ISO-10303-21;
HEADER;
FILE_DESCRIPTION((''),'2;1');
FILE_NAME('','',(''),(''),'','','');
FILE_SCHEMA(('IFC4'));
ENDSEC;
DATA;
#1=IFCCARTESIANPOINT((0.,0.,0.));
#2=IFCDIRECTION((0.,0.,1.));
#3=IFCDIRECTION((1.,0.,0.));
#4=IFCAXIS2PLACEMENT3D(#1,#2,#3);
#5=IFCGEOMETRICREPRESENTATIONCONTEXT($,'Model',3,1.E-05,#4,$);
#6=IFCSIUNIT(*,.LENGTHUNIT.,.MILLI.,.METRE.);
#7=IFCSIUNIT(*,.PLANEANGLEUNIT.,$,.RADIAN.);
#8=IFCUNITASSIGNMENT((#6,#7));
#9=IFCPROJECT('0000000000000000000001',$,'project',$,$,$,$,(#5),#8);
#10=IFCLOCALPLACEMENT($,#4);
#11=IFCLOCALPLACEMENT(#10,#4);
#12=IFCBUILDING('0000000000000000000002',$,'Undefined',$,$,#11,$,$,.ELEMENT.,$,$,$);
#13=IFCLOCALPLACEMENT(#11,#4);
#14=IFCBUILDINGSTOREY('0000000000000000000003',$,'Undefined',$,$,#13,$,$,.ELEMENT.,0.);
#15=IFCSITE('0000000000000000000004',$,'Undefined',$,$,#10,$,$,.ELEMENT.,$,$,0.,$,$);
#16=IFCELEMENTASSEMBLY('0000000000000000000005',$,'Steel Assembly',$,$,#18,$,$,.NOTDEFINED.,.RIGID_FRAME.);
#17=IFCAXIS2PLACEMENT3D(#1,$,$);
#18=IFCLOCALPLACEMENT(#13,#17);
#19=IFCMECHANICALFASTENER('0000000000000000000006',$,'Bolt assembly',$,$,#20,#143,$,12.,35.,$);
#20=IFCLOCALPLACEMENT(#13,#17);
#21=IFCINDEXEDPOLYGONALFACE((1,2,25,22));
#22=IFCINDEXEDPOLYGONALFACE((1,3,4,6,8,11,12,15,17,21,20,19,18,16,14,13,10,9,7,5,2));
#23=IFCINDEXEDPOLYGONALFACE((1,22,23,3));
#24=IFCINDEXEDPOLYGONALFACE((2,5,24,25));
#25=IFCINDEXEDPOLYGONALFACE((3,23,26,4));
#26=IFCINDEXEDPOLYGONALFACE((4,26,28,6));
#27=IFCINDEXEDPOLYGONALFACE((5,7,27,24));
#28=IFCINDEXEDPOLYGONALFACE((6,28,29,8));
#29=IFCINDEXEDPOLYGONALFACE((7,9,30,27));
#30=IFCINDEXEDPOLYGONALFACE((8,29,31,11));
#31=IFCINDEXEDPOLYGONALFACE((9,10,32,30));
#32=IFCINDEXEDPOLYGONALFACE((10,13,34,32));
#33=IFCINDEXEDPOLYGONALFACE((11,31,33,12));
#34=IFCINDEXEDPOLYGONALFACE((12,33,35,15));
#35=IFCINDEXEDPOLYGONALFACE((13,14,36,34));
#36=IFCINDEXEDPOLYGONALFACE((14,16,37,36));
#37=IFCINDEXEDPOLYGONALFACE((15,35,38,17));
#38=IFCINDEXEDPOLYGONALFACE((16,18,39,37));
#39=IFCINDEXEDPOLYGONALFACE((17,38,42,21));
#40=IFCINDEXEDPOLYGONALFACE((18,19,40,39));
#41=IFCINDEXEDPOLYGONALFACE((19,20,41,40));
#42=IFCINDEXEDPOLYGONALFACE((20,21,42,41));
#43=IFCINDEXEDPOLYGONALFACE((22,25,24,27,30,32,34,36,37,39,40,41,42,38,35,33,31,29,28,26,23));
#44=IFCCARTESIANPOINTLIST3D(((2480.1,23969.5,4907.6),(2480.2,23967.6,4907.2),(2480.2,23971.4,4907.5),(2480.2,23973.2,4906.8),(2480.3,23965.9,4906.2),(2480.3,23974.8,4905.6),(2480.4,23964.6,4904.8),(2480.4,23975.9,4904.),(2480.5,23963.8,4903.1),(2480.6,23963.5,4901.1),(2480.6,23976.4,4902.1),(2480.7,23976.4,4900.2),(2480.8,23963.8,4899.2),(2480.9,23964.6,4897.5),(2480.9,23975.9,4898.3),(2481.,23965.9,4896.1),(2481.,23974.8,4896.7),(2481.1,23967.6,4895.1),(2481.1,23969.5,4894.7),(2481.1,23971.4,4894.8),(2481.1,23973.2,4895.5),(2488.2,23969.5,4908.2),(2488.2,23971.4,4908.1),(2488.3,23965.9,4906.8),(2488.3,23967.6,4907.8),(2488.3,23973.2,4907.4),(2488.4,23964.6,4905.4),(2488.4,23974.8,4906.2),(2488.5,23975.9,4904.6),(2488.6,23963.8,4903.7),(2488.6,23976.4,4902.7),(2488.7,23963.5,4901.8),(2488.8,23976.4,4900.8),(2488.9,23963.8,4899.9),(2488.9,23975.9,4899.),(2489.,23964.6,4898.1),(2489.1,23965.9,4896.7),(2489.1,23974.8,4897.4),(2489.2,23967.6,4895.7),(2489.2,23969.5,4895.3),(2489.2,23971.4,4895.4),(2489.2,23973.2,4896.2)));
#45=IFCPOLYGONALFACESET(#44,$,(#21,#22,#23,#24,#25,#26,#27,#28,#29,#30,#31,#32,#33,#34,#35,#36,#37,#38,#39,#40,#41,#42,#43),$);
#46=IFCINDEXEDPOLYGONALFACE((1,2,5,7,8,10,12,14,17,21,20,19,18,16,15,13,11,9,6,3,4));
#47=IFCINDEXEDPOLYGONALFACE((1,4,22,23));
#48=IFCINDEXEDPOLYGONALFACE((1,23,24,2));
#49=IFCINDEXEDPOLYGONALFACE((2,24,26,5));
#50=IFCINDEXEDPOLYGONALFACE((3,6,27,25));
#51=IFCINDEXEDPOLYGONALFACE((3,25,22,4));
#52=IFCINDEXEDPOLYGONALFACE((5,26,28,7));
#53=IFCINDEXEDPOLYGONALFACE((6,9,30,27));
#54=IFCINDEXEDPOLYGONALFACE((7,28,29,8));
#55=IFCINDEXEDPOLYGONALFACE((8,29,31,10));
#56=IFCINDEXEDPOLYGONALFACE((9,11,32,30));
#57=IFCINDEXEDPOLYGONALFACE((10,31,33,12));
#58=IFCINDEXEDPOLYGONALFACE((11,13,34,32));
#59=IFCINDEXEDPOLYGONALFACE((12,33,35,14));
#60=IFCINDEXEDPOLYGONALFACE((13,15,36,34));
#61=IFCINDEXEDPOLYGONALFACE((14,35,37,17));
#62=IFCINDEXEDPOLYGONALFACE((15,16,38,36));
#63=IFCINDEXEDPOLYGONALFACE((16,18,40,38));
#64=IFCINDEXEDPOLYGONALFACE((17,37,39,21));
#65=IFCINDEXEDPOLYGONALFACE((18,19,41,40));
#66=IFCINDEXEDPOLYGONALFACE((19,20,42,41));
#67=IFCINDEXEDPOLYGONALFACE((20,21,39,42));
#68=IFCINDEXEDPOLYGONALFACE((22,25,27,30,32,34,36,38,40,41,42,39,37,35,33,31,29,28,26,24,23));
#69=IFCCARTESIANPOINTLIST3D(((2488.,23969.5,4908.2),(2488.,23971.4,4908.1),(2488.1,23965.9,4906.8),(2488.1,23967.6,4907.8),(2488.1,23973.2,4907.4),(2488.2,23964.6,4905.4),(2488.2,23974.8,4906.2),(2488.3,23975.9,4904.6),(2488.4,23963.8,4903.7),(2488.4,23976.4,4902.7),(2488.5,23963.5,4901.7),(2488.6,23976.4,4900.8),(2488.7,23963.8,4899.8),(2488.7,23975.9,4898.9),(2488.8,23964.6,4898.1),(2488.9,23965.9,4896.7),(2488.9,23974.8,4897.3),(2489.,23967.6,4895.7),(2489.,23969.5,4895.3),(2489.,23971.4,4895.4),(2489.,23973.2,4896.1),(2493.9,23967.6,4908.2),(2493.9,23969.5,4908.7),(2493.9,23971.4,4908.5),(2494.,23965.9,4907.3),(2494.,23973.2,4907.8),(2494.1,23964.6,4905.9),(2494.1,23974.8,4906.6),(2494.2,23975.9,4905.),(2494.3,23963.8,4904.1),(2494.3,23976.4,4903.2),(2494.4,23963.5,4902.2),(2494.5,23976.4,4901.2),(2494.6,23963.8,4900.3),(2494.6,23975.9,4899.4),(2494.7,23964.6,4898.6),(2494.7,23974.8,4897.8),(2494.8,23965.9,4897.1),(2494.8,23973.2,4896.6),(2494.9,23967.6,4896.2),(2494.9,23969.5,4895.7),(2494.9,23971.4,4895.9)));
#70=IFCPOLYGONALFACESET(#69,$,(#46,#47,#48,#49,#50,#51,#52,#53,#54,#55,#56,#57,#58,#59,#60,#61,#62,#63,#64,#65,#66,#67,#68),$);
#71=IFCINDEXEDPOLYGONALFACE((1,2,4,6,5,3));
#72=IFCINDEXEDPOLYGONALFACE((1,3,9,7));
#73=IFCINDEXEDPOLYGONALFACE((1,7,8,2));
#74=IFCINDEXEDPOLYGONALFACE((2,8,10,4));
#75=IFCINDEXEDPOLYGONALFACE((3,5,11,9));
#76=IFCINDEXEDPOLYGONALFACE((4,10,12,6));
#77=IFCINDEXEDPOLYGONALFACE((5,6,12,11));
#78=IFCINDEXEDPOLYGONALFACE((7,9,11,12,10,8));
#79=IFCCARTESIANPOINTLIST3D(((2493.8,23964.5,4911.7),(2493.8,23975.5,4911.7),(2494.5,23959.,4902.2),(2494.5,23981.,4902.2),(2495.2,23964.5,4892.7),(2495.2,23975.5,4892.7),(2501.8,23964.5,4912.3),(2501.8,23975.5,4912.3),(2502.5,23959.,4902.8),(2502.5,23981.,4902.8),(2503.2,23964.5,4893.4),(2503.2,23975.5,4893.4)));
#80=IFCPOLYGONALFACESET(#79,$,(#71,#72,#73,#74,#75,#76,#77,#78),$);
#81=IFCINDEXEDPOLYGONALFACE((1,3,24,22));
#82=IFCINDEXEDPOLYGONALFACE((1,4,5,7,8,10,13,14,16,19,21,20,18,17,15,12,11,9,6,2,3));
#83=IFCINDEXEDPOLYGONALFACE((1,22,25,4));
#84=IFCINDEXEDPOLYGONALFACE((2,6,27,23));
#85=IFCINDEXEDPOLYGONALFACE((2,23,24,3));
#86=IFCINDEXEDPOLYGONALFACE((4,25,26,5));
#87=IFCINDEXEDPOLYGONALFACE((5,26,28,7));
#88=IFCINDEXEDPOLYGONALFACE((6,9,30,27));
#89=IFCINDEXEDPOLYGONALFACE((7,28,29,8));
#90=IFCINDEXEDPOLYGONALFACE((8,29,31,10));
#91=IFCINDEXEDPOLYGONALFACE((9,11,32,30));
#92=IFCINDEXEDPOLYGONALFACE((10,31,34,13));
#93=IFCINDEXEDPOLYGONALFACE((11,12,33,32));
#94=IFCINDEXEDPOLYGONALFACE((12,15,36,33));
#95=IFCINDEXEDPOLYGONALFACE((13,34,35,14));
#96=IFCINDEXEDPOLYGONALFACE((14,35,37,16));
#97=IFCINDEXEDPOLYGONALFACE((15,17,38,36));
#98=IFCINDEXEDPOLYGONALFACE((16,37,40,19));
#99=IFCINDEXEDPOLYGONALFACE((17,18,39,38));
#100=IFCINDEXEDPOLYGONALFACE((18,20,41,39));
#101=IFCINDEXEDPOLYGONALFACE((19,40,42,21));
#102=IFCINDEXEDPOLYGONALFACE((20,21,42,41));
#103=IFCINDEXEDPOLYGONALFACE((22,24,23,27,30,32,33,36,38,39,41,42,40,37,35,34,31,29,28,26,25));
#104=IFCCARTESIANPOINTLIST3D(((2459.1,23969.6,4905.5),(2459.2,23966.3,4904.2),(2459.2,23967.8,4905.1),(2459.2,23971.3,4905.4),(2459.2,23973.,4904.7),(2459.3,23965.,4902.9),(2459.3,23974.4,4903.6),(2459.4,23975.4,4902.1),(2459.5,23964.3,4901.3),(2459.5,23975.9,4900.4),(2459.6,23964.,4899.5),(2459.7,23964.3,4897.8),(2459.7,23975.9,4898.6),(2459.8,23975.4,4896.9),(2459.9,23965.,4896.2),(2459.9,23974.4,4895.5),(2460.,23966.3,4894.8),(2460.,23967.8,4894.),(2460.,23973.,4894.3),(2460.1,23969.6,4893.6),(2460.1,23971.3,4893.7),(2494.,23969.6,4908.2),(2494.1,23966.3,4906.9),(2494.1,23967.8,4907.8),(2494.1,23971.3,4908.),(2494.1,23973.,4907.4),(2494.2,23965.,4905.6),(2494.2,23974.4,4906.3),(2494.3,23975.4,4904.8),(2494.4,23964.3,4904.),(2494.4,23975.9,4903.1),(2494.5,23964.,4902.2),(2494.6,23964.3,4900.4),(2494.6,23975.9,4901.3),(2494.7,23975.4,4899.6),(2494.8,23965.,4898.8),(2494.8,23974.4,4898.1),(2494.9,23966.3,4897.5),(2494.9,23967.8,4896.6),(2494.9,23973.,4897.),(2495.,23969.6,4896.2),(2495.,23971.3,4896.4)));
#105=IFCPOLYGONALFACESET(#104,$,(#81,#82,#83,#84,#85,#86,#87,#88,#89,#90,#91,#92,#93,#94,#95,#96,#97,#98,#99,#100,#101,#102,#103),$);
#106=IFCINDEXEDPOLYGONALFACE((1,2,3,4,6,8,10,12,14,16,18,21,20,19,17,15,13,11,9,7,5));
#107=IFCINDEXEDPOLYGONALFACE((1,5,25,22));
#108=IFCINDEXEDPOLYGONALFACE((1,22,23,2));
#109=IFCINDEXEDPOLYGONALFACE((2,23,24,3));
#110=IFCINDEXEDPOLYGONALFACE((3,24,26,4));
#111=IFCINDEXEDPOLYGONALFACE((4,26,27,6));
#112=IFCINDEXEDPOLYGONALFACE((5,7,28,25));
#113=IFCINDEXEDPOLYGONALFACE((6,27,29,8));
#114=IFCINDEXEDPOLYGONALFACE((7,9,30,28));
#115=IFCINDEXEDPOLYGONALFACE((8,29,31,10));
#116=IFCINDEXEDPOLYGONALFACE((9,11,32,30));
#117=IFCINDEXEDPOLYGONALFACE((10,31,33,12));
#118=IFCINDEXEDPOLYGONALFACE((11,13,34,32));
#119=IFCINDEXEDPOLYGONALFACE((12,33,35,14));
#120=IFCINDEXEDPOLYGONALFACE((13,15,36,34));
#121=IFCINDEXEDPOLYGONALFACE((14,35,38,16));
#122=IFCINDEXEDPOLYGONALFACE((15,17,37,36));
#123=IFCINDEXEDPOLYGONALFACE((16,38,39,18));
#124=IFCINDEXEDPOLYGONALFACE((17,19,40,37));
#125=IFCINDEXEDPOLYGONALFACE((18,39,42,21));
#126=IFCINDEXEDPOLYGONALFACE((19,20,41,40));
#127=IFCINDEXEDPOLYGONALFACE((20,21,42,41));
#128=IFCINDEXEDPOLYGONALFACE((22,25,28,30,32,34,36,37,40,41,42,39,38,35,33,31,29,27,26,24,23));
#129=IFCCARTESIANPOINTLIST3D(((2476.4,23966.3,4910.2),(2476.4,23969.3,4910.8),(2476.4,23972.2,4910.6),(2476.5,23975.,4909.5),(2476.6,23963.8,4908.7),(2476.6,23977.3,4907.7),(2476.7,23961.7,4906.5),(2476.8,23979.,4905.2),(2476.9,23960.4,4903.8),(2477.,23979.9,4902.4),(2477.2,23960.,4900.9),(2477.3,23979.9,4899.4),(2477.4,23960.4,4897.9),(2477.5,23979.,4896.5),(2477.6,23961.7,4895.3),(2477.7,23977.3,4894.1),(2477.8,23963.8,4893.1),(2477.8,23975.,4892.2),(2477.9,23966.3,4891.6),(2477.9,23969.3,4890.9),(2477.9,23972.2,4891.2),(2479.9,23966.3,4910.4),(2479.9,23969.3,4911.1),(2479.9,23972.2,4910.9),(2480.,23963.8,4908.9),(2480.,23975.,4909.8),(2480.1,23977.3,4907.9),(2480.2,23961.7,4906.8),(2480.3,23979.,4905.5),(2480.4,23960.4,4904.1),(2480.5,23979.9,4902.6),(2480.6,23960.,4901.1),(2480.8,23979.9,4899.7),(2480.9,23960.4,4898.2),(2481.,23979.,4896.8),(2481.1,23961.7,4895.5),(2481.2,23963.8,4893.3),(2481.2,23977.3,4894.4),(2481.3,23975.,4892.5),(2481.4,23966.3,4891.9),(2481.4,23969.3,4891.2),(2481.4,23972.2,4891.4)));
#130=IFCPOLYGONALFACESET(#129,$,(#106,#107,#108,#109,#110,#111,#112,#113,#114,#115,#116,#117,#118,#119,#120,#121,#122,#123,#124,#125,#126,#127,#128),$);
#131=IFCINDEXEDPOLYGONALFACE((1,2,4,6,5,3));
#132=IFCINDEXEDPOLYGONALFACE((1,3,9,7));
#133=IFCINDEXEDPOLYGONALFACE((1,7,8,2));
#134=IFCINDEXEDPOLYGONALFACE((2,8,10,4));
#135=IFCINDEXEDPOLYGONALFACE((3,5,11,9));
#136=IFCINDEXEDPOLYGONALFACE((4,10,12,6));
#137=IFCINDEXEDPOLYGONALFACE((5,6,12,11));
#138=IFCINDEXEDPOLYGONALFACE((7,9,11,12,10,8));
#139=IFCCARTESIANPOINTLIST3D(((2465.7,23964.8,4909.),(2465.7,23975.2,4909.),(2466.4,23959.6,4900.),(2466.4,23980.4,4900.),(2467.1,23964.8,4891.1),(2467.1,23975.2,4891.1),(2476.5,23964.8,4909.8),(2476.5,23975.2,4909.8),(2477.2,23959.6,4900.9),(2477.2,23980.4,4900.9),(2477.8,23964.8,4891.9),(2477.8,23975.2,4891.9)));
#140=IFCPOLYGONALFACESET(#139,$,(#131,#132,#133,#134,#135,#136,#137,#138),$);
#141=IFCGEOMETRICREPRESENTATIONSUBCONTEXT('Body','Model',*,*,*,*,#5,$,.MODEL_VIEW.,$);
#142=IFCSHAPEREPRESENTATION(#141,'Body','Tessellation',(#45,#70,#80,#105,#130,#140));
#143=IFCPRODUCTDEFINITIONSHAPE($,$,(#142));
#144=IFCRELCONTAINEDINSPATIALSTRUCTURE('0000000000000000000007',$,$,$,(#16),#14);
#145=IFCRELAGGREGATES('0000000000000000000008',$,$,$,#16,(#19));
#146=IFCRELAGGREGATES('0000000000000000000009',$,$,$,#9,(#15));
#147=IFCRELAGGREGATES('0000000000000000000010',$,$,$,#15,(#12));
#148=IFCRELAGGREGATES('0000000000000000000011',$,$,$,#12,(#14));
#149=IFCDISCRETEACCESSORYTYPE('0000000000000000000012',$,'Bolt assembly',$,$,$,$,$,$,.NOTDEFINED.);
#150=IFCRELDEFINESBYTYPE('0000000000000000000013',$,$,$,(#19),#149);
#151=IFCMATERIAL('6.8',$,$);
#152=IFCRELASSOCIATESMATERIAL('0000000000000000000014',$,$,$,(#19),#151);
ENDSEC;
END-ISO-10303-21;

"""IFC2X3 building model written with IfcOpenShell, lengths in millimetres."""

from ifc_helpers import new_model, si_unit, frame, origin_with_axes, origin_2d_with_axis, place, context, subcontext, project, spatial, polyline, circle, outline, extrude, source, transform, mapped, material, type_object, element, aggregate, save


model = new_model("IFC2X3")

# Units and contexts
model_context = context("Model", 3, precision=1e-05, world=origin_with_axes())
body_context = subcontext(model_context, "Body", "Model", "MODEL_VIEW")
ifc_project = project(units=[si_unit("LENGTHUNIT", "METRE", prefix="MILLI"), si_unit("PLANEANGLEUNIT", "RADIAN")], contexts=[model_context])

# Site, building, storey
site_placement = place(None, origin_with_axes())
site = spatial("IfcSite", under=ifc_project, at=site_placement, Name="Undefined", CompositionType="ELEMENT", RefElevation=0.0)
building_placement = place(site_placement, origin_with_axes())
building = spatial("IfcBuilding", under=site, at=building_placement, Name="Undefined", CompositionType="ELEMENT")
storey_placement = place(building_placement, origin_with_axes())
storey = spatial("IfcBuildingStorey", under=building, at=storey_placement, Name="Undefined", CompositionType="ELEMENT", Elevation=0.0)

# Element assembly, mechanical fastener
ifc_material_1 = material(Name="6.8")
discrete_accessory_type_1 = type_object("IfcDiscreteAccessoryType", Name="Bolt assembly")
shared_shape_1 = source(origin_with_axes(), body_context, "Body", "SweptSolid", [
    extrude(circle(Radius=6.5, at=origin_2d_with_axis()), frame((0.0, 2.9, 0.0), z_axis=(0.0, 1.0, 0.0), x_axis=(1.0, 0.0, 0.0)), (0.0, 0.0, 1.0), 8.1),
    extrude(circle(Radius=6.5, at=origin_2d_with_axis()), frame((0.0, -2.9, 0.0), z_axis=(0.0, 1.0, 0.0), x_axis=(1.0, 0.0, 0.0)), (0.0, 0.0, 1.0), 5.9),
    extrude(outline(polyline([(11.0, 0.0), (5.5, 9.5), (-5.5, 9.5), (-11.0, 0.0), (-5.5, -9.5), (5.5, -9.5), (11.0, 0.0)])), frame((0.0, -11.0, 0.0), z_axis=(0.0, 1.0, 0.0), x_axis=(1.0, 0.0, 0.0)), (0.0, 0.0, 1.0), 8.0),
    extrude(circle(Radius=6.0, at=origin_2d_with_axis()), frame((0.0, -3.0, 0.0), z_axis=(0.0, 1.0, 0.0), x_axis=(1.0, 0.0, 0.0)), (0.0, 0.0, 1.0), 35.0),
    extrude(circle(Radius=10.0, at=origin_2d_with_axis()), frame((0.0, 11.0, 0.0), z_axis=(0.0, 1.0, 0.0), x_axis=(1.0, 0.0, 0.0)), (0.0, 0.0, 1.0), 3.5),
    extrude(outline(polyline([(10.4, 0.0), (5.2, 9.0), (-5.2, 9.0), (-10.4, 0.0), (-5.2, -9.0), (5.2, -9.0), (10.4, 0.0)])), frame((0.0, 14.5, 0.0), z_axis=(0.0, 1.0, 0.0), x_axis=(1.0, 0.0, 0.0)), (0.0, 0.0, 1.0), 10.8),
])
assembly_1_placement = place(storey_placement, origin_with_axes())
assembly_1 = element("IfcElementAssembly", 1, at=assembly_1_placement, inside=storey, Name="Steel Assembly", AssemblyPlace="NOTDEFINED", PredefinedType="RIGID_FRAME")
mechanical_fastener_1_placement = place(assembly_1_placement, frame((2491.6, 23970.0, 4902.0), z_axis=(0.076696, 0.0, -0.997054), x_axis=(0.0, -1.0, 0.0)))
mechanical_fastener_1 = element("IfcMechanicalFastener", 2, at=mechanical_fastener_1_placement, type_object=discrete_accessory_type_1, material=ifc_material_1, Name="Bolt assembly", NominalDiameter=12.0, NominalLength=35.0, context=body_context, shape_type="MappedRepresentation", body=[
    mapped(shared_shape_1, transform((0.0, 0.0, 0.0))),
])
aggregate(assembly_1, [mechanical_fastener_1])

save(model, "model.ifc")
